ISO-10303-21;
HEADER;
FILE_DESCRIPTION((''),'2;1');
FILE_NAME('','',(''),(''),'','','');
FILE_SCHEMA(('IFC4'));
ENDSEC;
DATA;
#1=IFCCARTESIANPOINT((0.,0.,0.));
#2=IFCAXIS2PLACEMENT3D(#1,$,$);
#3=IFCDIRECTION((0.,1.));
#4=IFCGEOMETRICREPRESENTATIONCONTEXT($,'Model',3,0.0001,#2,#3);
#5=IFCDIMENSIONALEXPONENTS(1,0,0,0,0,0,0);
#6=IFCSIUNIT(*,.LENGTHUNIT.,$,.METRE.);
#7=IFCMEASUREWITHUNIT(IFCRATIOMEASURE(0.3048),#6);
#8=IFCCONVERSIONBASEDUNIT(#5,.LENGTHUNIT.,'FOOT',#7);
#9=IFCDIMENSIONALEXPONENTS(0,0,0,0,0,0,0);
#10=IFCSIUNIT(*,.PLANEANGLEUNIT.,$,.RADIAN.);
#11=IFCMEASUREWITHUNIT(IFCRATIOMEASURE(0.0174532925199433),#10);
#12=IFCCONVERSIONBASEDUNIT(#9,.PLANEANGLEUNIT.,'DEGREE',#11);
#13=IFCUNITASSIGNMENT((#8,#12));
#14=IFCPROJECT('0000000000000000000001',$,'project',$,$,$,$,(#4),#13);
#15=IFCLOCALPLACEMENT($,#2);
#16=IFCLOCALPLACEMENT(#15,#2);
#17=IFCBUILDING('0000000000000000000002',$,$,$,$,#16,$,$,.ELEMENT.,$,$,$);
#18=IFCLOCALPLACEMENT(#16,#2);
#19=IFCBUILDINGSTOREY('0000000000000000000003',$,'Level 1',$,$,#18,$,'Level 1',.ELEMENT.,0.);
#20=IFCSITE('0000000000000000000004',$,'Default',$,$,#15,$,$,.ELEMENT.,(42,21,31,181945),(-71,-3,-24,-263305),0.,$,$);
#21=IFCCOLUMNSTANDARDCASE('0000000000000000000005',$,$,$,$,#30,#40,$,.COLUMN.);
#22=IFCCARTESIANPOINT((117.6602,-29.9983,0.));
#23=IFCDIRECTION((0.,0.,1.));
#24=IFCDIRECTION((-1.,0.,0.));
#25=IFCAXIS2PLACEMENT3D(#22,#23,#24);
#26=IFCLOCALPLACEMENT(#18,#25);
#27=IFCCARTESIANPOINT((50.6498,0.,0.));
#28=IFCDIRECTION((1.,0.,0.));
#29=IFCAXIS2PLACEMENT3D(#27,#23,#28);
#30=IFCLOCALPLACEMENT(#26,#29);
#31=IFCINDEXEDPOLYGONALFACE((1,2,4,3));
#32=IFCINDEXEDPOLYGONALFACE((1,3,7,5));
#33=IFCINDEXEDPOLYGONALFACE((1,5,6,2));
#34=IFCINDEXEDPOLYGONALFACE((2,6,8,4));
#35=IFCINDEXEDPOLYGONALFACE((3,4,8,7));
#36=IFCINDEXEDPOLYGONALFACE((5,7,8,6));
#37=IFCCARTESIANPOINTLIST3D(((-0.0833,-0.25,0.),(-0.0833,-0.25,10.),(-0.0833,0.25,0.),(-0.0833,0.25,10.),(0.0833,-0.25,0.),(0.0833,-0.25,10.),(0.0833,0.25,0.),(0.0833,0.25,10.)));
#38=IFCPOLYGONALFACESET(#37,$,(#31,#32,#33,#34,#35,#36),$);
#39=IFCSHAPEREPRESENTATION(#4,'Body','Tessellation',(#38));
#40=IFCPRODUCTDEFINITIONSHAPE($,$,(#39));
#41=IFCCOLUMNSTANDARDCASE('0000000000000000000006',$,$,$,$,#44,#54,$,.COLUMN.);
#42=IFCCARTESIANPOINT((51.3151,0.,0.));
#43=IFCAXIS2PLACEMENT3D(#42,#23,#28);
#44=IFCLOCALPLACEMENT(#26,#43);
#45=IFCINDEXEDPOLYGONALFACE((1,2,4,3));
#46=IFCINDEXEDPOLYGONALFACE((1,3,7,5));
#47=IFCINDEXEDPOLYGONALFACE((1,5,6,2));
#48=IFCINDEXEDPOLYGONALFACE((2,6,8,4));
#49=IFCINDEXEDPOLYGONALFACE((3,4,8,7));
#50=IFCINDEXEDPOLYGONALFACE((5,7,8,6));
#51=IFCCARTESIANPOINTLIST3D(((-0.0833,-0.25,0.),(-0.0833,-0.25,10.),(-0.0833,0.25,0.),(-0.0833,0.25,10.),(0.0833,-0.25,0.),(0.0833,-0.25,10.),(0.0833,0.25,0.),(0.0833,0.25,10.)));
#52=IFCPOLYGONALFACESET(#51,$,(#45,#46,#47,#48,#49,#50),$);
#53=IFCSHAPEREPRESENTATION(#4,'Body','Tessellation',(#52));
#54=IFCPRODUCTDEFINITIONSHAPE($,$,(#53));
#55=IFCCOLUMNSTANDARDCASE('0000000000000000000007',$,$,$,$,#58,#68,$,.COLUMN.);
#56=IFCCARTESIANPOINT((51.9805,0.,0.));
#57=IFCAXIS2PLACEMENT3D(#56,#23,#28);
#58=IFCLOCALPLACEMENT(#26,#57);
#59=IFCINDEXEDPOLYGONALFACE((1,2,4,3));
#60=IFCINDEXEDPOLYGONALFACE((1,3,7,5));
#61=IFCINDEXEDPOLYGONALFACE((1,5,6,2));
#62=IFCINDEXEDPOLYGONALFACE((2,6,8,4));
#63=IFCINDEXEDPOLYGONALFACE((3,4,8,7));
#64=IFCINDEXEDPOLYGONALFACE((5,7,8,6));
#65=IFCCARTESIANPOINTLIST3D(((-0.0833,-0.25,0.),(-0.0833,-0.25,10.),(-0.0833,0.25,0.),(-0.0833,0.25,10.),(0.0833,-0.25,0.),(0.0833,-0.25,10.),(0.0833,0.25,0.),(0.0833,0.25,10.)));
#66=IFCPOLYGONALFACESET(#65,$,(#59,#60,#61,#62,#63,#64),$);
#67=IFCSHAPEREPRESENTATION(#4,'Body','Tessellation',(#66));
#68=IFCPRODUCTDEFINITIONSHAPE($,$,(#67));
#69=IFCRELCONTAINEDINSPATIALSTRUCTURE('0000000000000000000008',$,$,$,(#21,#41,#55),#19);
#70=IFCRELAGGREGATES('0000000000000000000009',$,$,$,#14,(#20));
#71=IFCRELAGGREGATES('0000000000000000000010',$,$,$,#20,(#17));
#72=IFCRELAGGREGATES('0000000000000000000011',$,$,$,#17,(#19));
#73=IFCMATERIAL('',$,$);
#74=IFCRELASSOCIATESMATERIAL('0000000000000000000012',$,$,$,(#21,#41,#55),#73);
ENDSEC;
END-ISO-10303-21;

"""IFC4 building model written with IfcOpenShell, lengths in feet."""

from ifc_helpers import new_model, entity, si_unit, converted_unit, direction, frame, origin, place, context, project, spatial, rectangle, extrude, material, element, save


model = new_model("IFC4")

# Units and contexts
model_context = context("Model", 3, precision=0.0001, world=origin(), true_north=direction((0.0, 1.0)))
ifc_project = project(units=[converted_unit("LENGTHUNIT", "FOOT", entity("IfcRatioMeasure", 0.3048), si_unit("LENGTHUNIT", "METRE"), dimensions=[1, 0, 0, 0, 0, 0, 0]), converted_unit("PLANEANGLEUNIT", "DEGREE", entity("IfcRatioMeasure", 0.0174532925199433), si_unit("PLANEANGLEUNIT", "RADIAN"), dimensions=[0, 0, 0, 0, 0, 0, 0])], contexts=[model_context])

# Site, building, storey
site_placement = place(None, origin())
site = spatial("IfcSite", under=ifc_project, at=site_placement, Name="Default", CompositionType="ELEMENT", RefLatitude=(42, 21, 31, 181945), RefLongitude=(-71, -3, -24, -263305), RefElevation=0.0)
building_placement = place(site_placement, origin())
building = spatial("IfcBuilding", under=site, at=building_placement, CompositionType="ELEMENT")
storey_placement = place(building_placement, origin())
storey = spatial("IfcBuildingStorey", under=building, at=storey_placement, Name="Level 1", LongName="Level 1", CompositionType="ELEMENT", Elevation=0.0)

# Columns
ifc_material = material(Name="")
placement = place(storey_placement, frame((117.6602, -29.9983, 0.0), z_axis=(0.0, 0.0, 1.0), x_axis=(-1.0, 0.0, 0.0)))
for number, where, z_axis, x_axis in (
    (1, (50.6498, 0.0, 0.0), (0.0, 0.0, 1.0), (1.0, 0.0, 0.0)),
    (2, (51.3151, 0.0, 0.0), (0.0, 0.0, 1.0), (1.0, 0.0, 0.0)),
    (3, (51.9805, 0.0, 0.0), (0.0, 0.0, 1.0), (1.0, 0.0, 0.0)),
):
    element("IfcColumnStandardCase", number, at=place(placement, frame(where, z_axis=z_axis, x_axis=x_axis)), inside=storey, material=ifc_material, PredefinedType="COLUMN", context=model_context, shape_type="SweptSolid", body=[
        extrude(rectangle(XDim=0.1667, YDim=0.5), origin(), (0.0, 0.0, 1.0), 10.0),
    ])

save(model, "model.ifc")
